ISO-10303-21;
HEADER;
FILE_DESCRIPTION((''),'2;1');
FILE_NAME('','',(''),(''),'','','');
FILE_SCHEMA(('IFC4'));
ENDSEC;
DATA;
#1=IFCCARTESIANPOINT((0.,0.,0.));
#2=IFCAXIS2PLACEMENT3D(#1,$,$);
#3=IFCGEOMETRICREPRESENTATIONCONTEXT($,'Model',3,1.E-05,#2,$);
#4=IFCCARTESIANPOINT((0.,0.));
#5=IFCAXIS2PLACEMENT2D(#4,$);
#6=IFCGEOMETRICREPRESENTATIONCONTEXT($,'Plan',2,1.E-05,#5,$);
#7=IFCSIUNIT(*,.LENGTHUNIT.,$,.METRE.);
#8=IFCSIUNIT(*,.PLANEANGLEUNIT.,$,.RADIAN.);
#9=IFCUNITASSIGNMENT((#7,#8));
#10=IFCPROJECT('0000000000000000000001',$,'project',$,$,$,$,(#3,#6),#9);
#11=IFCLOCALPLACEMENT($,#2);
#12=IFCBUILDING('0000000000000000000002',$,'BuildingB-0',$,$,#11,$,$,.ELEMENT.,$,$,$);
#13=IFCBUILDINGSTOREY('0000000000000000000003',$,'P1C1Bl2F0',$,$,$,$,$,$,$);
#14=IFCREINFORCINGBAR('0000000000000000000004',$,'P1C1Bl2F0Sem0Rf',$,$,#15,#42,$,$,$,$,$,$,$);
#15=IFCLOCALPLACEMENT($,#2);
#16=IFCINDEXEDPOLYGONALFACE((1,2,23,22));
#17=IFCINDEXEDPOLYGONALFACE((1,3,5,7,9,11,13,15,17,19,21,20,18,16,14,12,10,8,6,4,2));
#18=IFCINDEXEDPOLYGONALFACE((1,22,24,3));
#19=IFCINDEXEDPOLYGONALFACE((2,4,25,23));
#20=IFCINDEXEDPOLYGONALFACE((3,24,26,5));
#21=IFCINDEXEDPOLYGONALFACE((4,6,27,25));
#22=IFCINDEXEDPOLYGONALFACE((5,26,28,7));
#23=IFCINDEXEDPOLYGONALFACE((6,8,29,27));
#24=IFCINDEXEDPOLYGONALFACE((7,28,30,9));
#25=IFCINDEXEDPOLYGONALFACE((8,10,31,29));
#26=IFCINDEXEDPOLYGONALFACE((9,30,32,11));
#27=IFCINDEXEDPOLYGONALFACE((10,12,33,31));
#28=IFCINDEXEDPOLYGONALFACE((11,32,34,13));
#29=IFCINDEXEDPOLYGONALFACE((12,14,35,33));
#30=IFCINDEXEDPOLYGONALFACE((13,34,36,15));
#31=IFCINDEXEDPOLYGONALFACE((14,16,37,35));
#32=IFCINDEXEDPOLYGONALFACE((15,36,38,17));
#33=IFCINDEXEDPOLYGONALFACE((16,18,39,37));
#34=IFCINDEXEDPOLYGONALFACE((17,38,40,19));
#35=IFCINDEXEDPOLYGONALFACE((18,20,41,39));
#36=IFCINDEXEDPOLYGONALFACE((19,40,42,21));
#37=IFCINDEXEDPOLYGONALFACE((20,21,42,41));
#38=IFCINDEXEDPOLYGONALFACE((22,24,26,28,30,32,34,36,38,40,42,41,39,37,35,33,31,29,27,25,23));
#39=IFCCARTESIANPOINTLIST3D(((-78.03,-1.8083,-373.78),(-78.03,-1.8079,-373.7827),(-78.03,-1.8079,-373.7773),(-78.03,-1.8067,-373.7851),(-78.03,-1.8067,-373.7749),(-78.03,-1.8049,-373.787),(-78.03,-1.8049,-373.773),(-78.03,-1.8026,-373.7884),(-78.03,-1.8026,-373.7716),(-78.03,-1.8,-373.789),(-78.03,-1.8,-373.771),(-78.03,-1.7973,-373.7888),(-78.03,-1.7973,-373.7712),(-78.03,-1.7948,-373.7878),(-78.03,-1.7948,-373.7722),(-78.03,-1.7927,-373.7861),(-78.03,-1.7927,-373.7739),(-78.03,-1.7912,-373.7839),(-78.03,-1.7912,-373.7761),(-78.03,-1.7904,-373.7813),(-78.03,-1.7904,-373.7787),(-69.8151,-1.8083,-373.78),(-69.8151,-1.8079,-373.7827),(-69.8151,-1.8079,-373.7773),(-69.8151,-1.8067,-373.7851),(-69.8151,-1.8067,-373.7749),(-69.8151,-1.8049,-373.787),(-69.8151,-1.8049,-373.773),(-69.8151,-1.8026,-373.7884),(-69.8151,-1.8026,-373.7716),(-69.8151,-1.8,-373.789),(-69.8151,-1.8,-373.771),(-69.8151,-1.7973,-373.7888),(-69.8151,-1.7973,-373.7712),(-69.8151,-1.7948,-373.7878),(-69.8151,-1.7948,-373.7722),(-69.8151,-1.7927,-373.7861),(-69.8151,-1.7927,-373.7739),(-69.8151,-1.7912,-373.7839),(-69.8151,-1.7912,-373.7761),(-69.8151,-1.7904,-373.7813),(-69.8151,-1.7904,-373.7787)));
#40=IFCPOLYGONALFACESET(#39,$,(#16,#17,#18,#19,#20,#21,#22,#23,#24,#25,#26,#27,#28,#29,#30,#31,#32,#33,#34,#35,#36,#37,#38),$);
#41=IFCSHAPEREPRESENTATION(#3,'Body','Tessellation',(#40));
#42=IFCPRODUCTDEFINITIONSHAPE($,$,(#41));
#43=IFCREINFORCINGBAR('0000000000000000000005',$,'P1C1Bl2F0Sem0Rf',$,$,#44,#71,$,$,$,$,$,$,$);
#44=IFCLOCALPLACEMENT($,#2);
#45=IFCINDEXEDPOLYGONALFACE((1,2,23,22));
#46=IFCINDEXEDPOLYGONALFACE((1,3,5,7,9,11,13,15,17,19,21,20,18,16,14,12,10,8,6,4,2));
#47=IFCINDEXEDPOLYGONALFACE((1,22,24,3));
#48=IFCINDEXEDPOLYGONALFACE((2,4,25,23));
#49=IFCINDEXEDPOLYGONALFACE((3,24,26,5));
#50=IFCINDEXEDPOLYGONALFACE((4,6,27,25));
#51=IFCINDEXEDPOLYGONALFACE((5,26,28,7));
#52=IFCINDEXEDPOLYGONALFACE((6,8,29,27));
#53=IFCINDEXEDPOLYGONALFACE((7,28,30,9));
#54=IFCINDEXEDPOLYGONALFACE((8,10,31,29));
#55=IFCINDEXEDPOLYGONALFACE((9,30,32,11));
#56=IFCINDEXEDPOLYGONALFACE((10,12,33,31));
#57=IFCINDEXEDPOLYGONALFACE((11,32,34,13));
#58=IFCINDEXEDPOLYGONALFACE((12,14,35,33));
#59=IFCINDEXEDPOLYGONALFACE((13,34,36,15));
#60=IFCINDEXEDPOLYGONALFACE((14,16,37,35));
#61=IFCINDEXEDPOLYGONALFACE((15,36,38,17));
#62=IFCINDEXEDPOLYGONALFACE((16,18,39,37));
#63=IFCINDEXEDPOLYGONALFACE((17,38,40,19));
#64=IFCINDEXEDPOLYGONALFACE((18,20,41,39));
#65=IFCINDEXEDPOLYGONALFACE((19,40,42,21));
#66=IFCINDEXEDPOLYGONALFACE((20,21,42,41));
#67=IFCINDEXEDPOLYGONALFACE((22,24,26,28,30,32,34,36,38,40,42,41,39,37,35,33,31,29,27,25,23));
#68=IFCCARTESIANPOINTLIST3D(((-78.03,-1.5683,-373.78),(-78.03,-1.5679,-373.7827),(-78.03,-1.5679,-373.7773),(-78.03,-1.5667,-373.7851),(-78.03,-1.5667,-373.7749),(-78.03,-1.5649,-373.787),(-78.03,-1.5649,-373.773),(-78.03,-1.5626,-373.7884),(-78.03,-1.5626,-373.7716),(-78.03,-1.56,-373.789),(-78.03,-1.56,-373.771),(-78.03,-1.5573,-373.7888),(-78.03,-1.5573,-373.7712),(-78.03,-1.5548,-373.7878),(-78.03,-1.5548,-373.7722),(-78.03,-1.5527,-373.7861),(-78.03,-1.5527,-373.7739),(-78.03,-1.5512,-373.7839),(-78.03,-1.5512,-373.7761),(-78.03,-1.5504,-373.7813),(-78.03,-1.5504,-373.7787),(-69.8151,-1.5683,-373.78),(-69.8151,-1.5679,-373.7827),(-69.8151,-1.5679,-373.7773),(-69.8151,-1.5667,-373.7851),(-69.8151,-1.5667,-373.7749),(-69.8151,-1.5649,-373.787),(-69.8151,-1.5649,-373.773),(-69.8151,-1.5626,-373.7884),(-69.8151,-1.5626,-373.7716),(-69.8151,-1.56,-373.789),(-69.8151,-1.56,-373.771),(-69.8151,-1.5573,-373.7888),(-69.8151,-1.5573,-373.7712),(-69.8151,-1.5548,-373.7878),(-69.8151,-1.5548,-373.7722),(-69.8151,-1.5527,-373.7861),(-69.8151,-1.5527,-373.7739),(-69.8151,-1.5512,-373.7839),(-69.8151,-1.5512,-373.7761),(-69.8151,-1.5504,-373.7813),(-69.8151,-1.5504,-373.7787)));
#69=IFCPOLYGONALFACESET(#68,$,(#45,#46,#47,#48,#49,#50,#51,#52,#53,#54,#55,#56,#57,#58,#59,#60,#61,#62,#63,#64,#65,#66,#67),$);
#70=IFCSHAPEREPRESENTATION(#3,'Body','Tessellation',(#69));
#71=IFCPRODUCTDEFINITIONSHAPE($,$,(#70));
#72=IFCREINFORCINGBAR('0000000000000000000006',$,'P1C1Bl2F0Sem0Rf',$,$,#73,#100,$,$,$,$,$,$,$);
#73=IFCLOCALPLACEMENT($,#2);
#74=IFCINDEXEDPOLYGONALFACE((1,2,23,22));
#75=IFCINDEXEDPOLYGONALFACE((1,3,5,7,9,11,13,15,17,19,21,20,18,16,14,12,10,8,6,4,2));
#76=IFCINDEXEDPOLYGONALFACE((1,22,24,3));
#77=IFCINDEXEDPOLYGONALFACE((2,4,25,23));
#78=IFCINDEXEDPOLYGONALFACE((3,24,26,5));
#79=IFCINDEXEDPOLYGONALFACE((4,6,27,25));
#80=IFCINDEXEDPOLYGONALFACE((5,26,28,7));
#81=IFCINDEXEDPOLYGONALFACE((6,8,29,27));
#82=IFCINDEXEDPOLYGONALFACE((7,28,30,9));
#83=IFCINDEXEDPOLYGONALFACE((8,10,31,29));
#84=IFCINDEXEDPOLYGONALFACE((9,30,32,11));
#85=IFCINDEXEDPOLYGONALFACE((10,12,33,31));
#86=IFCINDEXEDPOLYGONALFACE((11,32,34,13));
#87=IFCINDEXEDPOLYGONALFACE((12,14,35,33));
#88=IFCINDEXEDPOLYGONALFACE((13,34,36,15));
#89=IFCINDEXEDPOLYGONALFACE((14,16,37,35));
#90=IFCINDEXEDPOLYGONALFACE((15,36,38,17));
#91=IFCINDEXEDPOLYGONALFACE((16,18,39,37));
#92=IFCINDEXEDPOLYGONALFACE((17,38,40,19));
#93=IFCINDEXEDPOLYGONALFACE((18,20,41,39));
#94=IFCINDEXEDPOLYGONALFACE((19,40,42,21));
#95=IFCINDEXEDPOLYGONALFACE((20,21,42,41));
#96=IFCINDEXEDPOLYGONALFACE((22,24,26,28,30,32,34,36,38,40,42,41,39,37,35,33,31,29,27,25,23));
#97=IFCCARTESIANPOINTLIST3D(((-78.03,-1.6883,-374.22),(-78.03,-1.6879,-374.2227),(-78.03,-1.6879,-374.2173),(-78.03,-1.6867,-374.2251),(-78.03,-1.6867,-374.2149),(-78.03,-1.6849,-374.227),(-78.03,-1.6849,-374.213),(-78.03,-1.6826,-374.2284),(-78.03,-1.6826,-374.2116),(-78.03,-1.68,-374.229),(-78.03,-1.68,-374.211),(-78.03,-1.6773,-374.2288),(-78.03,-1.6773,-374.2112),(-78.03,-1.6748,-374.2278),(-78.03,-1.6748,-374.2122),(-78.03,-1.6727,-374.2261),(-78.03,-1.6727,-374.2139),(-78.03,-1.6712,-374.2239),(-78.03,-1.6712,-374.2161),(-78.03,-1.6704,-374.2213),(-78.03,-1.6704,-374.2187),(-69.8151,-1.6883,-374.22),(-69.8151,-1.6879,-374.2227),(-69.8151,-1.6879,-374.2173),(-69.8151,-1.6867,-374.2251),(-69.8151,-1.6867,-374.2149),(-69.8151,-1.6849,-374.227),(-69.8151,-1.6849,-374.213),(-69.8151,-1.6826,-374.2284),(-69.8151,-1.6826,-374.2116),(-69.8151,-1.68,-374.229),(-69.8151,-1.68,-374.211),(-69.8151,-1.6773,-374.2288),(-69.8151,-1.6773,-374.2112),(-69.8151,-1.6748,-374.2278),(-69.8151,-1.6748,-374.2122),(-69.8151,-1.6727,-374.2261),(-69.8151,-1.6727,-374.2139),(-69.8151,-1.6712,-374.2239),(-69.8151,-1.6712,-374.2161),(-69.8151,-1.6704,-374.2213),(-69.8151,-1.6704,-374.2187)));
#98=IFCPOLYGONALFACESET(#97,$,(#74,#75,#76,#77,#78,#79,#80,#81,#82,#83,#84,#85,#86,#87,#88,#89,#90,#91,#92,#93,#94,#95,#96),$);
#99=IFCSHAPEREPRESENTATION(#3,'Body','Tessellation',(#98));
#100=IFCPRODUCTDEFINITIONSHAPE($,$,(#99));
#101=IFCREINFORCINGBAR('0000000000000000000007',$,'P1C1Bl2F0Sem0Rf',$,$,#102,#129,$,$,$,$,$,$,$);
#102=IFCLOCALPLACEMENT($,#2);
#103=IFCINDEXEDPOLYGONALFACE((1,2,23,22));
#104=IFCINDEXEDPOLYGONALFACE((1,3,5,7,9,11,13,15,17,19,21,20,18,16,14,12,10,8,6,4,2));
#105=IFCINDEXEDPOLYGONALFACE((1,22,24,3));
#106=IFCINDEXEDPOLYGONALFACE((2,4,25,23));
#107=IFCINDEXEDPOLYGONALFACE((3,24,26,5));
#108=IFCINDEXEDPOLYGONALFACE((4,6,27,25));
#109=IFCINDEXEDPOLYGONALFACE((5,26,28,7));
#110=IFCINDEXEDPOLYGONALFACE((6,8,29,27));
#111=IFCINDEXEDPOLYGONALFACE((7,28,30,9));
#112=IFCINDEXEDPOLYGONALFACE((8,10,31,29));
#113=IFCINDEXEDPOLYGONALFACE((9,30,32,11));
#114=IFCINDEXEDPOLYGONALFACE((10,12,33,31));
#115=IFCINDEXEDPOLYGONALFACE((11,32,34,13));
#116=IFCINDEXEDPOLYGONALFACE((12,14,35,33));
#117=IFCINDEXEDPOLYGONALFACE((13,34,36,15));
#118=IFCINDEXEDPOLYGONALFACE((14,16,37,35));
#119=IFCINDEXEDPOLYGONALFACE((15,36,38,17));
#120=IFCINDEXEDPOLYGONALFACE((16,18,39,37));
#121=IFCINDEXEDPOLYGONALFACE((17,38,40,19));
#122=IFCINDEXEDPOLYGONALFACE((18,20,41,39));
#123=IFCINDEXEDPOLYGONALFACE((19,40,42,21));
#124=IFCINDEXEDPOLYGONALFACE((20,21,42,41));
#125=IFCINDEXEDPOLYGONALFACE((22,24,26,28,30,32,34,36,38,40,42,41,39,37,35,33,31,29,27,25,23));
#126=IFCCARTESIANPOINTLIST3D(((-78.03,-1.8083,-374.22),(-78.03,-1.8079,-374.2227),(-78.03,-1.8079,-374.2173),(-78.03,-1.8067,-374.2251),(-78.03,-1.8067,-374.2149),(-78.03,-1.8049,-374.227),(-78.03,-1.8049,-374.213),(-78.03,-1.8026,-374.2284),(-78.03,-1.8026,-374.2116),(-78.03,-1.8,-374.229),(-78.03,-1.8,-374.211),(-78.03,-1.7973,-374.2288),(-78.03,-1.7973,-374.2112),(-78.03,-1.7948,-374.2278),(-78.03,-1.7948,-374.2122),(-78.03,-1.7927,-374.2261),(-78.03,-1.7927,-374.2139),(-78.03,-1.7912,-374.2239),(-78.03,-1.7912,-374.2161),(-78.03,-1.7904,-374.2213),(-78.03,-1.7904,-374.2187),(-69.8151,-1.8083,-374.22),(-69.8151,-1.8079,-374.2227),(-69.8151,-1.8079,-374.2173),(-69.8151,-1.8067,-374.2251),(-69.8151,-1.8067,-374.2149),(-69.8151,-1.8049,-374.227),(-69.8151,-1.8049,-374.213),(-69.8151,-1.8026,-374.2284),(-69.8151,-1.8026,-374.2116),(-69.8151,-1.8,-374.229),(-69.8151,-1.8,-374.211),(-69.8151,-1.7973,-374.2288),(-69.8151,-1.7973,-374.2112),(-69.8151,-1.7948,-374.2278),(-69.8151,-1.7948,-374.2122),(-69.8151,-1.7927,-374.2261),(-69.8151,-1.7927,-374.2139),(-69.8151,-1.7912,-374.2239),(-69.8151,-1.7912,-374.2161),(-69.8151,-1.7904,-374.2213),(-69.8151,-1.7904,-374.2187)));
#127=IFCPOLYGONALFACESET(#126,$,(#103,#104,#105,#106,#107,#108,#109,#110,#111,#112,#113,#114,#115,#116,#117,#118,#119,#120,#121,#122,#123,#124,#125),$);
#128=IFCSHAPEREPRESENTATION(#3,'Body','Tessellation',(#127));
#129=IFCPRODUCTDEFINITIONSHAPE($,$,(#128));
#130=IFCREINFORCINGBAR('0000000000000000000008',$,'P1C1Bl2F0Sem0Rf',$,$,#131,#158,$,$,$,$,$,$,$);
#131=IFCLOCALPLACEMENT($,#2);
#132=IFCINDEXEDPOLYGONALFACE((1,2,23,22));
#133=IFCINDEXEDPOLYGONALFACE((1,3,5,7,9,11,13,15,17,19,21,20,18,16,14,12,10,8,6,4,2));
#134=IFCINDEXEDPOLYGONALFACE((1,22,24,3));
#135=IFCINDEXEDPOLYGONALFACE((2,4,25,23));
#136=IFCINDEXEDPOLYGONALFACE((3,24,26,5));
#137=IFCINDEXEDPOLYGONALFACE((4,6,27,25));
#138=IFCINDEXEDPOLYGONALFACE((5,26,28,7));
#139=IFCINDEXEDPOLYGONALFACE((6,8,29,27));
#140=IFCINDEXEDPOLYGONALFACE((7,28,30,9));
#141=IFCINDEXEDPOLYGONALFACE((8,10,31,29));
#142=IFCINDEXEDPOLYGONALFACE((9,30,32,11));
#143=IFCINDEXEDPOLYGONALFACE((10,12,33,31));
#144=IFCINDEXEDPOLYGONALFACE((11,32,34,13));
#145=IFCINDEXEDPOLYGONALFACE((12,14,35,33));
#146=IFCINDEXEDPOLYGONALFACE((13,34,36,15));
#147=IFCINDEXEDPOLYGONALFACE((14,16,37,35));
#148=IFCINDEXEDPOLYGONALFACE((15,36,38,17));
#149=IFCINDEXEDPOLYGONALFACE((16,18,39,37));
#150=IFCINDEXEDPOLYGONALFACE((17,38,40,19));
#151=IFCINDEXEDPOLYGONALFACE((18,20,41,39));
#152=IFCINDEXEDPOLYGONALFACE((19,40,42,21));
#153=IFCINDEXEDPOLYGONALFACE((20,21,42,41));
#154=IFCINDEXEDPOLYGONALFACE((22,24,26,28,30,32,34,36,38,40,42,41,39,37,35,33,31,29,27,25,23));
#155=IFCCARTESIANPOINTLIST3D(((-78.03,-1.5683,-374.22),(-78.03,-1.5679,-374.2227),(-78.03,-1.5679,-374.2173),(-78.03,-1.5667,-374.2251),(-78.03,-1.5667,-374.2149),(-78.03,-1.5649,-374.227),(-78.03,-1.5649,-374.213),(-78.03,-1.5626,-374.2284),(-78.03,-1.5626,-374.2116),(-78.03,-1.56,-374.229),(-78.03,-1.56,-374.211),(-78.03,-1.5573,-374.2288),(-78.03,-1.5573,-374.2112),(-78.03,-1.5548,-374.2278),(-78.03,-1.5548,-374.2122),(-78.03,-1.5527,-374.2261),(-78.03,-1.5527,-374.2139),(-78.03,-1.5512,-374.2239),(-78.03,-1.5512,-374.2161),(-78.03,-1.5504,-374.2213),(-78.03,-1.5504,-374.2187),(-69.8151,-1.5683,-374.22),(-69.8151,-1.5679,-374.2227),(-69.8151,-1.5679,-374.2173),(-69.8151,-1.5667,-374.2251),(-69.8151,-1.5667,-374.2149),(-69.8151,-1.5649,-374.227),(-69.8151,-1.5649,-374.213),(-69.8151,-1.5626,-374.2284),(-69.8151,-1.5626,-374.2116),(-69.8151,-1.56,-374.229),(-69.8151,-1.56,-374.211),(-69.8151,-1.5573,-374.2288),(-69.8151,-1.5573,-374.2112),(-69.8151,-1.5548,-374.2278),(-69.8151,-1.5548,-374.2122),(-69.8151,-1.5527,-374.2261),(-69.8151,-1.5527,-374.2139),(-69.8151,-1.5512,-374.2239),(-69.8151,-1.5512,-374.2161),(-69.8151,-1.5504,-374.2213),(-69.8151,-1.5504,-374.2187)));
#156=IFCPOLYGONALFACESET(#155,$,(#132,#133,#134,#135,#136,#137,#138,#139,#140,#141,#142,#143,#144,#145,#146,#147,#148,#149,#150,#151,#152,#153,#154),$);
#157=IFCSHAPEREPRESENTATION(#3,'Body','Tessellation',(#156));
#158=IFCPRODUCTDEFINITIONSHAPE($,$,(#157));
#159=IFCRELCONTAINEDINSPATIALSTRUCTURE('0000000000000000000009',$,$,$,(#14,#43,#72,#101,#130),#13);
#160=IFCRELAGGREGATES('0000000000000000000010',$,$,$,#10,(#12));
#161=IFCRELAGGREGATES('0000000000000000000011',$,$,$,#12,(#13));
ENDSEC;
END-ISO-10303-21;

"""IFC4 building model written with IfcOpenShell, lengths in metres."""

from ifc_helpers import new_model, entity, si_unit, origin, origin_2d, place, context, project, spatial, element, save


model = new_model("IFC4")

# Units and contexts
model_context = context("Model", 3, precision=1e-05, world=origin())
plan_context = context("Plan", 2, precision=1e-05, world=origin_2d())
ifc_project = project(units=[si_unit("LENGTHUNIT", "METRE"), si_unit("PLANEANGLEUNIT", "RADIAN")], contexts=[model_context, plan_context])

# Building, storey
building_placement = place(None, origin())
building = spatial("IfcBuilding", under=ifc_project, at=building_placement, Name="BuildingB-0", CompositionType="ELEMENT")
storey = spatial("IfcBuildingStorey", under=building, Name="P1C1Bl2F0")

# Reinforcing bars
element("IfcReinforcingBar", 1, inside=storey, Name="P1C1Bl2F0Sem0Rf", context=model_context, shape_type="SweptSolid", body=[
    entity("IfcSurfaceCurveSweptAreaSolid", entity("IfcCircleProfileDef", "AREA", None, None, 0.009), None, entity("IfcPolyline", [entity("IfcCartesianPoint", [78.03, 1.7993, 373.78]), entity("IfcCartesianPoint", [69.8151, 1.7993, 373.78])]), None, None, entity("IfcPlane", entity("IfcAxis2Placement3D", entity("IfcCartesianPoint", [78.03, 1.7993, 373.78]), entity("IfcDirection", [0.0, 0.0, 1.0]), entity("IfcDirection", [1.0, 0.0, 0.0])))),
])
element("IfcReinforcingBar", 2, inside=storey, Name="P1C1Bl2F0Sem0Rf", context=model_context, shape_type="SweptSolid", body=[
    entity("IfcSurfaceCurveSweptAreaSolid", entity("IfcCircleProfileDef", "AREA", None, None, 0.009), None, entity("IfcPolyline", [entity("IfcCartesianPoint", [78.03, 1.5593, 373.78]), entity("IfcCartesianPoint", [69.8151, 1.5593, 373.78])]), None, None, entity("IfcPlane", entity("IfcAxis2Placement3D", entity("IfcCartesianPoint", [78.03, 1.5593, 373.78]), entity("IfcDirection", [0.0, 0.0, 1.0]), entity("IfcDirection", [1.0, 0.0, 0.0])))),
])
element("IfcReinforcingBar", 3, inside=storey, Name="P1C1Bl2F0Sem0Rf", context=model_context, shape_type="SweptSolid", body=[
    entity("IfcSurfaceCurveSweptAreaSolid", entity("IfcCircleProfileDef", "AREA", None, None, 0.009), None, entity("IfcPolyline", [entity("IfcCartesianPoint", [78.03, 1.6793, 374.22]), entity("IfcCartesianPoint", [69.8151, 1.6793, 374.22])]), None, None, entity("IfcPlane", entity("IfcAxis2Placement3D", entity("IfcCartesianPoint", [78.03, 1.6793, 374.22]), entity("IfcDirection", [0.0, 0.0, 1.0]), entity("IfcDirection", [1.0, 0.0, 0.0])))),
])
element("IfcReinforcingBar", 4, inside=storey, Name="P1C1Bl2F0Sem0Rf", context=model_context, shape_type="SweptSolid", body=[
    entity("IfcSurfaceCurveSweptAreaSolid", entity("IfcCircleProfileDef", "AREA", None, None, 0.009), None, entity("IfcPolyline", [entity("IfcCartesianPoint", [78.03, 1.7993, 374.22]), entity("IfcCartesianPoint", [69.8151, 1.7993, 374.22])]), None, None, entity("IfcPlane", entity("IfcAxis2Placement3D", entity("IfcCartesianPoint", [78.03, 1.7993, 374.22]), entity("IfcDirection", [0.0, 0.0, 1.0]), entity("IfcDirection", [1.0, 0.0, 0.0])))),
])
element("IfcReinforcingBar", 5, inside=storey, Name="P1C1Bl2F0Sem0Rf", context=model_context, shape_type="SweptSolid", body=[
    entity("IfcSurfaceCurveSweptAreaSolid", entity("IfcCircleProfileDef", "AREA", None, None, 0.009), None, entity("IfcPolyline", [entity("IfcCartesianPoint", [78.03, 1.5593, 374.22]), entity("IfcCartesianPoint", [69.8151, 1.5593, 374.22])]), None, None, entity("IfcPlane", entity("IfcAxis2Placement3D", entity("IfcCartesianPoint", [78.03, 1.5593, 374.22]), entity("IfcDirection", [0.0, 0.0, 1.0]), entity("IfcDirection", [1.0, 0.0, 0.0])))),
])

save(model, "model.ifc")
